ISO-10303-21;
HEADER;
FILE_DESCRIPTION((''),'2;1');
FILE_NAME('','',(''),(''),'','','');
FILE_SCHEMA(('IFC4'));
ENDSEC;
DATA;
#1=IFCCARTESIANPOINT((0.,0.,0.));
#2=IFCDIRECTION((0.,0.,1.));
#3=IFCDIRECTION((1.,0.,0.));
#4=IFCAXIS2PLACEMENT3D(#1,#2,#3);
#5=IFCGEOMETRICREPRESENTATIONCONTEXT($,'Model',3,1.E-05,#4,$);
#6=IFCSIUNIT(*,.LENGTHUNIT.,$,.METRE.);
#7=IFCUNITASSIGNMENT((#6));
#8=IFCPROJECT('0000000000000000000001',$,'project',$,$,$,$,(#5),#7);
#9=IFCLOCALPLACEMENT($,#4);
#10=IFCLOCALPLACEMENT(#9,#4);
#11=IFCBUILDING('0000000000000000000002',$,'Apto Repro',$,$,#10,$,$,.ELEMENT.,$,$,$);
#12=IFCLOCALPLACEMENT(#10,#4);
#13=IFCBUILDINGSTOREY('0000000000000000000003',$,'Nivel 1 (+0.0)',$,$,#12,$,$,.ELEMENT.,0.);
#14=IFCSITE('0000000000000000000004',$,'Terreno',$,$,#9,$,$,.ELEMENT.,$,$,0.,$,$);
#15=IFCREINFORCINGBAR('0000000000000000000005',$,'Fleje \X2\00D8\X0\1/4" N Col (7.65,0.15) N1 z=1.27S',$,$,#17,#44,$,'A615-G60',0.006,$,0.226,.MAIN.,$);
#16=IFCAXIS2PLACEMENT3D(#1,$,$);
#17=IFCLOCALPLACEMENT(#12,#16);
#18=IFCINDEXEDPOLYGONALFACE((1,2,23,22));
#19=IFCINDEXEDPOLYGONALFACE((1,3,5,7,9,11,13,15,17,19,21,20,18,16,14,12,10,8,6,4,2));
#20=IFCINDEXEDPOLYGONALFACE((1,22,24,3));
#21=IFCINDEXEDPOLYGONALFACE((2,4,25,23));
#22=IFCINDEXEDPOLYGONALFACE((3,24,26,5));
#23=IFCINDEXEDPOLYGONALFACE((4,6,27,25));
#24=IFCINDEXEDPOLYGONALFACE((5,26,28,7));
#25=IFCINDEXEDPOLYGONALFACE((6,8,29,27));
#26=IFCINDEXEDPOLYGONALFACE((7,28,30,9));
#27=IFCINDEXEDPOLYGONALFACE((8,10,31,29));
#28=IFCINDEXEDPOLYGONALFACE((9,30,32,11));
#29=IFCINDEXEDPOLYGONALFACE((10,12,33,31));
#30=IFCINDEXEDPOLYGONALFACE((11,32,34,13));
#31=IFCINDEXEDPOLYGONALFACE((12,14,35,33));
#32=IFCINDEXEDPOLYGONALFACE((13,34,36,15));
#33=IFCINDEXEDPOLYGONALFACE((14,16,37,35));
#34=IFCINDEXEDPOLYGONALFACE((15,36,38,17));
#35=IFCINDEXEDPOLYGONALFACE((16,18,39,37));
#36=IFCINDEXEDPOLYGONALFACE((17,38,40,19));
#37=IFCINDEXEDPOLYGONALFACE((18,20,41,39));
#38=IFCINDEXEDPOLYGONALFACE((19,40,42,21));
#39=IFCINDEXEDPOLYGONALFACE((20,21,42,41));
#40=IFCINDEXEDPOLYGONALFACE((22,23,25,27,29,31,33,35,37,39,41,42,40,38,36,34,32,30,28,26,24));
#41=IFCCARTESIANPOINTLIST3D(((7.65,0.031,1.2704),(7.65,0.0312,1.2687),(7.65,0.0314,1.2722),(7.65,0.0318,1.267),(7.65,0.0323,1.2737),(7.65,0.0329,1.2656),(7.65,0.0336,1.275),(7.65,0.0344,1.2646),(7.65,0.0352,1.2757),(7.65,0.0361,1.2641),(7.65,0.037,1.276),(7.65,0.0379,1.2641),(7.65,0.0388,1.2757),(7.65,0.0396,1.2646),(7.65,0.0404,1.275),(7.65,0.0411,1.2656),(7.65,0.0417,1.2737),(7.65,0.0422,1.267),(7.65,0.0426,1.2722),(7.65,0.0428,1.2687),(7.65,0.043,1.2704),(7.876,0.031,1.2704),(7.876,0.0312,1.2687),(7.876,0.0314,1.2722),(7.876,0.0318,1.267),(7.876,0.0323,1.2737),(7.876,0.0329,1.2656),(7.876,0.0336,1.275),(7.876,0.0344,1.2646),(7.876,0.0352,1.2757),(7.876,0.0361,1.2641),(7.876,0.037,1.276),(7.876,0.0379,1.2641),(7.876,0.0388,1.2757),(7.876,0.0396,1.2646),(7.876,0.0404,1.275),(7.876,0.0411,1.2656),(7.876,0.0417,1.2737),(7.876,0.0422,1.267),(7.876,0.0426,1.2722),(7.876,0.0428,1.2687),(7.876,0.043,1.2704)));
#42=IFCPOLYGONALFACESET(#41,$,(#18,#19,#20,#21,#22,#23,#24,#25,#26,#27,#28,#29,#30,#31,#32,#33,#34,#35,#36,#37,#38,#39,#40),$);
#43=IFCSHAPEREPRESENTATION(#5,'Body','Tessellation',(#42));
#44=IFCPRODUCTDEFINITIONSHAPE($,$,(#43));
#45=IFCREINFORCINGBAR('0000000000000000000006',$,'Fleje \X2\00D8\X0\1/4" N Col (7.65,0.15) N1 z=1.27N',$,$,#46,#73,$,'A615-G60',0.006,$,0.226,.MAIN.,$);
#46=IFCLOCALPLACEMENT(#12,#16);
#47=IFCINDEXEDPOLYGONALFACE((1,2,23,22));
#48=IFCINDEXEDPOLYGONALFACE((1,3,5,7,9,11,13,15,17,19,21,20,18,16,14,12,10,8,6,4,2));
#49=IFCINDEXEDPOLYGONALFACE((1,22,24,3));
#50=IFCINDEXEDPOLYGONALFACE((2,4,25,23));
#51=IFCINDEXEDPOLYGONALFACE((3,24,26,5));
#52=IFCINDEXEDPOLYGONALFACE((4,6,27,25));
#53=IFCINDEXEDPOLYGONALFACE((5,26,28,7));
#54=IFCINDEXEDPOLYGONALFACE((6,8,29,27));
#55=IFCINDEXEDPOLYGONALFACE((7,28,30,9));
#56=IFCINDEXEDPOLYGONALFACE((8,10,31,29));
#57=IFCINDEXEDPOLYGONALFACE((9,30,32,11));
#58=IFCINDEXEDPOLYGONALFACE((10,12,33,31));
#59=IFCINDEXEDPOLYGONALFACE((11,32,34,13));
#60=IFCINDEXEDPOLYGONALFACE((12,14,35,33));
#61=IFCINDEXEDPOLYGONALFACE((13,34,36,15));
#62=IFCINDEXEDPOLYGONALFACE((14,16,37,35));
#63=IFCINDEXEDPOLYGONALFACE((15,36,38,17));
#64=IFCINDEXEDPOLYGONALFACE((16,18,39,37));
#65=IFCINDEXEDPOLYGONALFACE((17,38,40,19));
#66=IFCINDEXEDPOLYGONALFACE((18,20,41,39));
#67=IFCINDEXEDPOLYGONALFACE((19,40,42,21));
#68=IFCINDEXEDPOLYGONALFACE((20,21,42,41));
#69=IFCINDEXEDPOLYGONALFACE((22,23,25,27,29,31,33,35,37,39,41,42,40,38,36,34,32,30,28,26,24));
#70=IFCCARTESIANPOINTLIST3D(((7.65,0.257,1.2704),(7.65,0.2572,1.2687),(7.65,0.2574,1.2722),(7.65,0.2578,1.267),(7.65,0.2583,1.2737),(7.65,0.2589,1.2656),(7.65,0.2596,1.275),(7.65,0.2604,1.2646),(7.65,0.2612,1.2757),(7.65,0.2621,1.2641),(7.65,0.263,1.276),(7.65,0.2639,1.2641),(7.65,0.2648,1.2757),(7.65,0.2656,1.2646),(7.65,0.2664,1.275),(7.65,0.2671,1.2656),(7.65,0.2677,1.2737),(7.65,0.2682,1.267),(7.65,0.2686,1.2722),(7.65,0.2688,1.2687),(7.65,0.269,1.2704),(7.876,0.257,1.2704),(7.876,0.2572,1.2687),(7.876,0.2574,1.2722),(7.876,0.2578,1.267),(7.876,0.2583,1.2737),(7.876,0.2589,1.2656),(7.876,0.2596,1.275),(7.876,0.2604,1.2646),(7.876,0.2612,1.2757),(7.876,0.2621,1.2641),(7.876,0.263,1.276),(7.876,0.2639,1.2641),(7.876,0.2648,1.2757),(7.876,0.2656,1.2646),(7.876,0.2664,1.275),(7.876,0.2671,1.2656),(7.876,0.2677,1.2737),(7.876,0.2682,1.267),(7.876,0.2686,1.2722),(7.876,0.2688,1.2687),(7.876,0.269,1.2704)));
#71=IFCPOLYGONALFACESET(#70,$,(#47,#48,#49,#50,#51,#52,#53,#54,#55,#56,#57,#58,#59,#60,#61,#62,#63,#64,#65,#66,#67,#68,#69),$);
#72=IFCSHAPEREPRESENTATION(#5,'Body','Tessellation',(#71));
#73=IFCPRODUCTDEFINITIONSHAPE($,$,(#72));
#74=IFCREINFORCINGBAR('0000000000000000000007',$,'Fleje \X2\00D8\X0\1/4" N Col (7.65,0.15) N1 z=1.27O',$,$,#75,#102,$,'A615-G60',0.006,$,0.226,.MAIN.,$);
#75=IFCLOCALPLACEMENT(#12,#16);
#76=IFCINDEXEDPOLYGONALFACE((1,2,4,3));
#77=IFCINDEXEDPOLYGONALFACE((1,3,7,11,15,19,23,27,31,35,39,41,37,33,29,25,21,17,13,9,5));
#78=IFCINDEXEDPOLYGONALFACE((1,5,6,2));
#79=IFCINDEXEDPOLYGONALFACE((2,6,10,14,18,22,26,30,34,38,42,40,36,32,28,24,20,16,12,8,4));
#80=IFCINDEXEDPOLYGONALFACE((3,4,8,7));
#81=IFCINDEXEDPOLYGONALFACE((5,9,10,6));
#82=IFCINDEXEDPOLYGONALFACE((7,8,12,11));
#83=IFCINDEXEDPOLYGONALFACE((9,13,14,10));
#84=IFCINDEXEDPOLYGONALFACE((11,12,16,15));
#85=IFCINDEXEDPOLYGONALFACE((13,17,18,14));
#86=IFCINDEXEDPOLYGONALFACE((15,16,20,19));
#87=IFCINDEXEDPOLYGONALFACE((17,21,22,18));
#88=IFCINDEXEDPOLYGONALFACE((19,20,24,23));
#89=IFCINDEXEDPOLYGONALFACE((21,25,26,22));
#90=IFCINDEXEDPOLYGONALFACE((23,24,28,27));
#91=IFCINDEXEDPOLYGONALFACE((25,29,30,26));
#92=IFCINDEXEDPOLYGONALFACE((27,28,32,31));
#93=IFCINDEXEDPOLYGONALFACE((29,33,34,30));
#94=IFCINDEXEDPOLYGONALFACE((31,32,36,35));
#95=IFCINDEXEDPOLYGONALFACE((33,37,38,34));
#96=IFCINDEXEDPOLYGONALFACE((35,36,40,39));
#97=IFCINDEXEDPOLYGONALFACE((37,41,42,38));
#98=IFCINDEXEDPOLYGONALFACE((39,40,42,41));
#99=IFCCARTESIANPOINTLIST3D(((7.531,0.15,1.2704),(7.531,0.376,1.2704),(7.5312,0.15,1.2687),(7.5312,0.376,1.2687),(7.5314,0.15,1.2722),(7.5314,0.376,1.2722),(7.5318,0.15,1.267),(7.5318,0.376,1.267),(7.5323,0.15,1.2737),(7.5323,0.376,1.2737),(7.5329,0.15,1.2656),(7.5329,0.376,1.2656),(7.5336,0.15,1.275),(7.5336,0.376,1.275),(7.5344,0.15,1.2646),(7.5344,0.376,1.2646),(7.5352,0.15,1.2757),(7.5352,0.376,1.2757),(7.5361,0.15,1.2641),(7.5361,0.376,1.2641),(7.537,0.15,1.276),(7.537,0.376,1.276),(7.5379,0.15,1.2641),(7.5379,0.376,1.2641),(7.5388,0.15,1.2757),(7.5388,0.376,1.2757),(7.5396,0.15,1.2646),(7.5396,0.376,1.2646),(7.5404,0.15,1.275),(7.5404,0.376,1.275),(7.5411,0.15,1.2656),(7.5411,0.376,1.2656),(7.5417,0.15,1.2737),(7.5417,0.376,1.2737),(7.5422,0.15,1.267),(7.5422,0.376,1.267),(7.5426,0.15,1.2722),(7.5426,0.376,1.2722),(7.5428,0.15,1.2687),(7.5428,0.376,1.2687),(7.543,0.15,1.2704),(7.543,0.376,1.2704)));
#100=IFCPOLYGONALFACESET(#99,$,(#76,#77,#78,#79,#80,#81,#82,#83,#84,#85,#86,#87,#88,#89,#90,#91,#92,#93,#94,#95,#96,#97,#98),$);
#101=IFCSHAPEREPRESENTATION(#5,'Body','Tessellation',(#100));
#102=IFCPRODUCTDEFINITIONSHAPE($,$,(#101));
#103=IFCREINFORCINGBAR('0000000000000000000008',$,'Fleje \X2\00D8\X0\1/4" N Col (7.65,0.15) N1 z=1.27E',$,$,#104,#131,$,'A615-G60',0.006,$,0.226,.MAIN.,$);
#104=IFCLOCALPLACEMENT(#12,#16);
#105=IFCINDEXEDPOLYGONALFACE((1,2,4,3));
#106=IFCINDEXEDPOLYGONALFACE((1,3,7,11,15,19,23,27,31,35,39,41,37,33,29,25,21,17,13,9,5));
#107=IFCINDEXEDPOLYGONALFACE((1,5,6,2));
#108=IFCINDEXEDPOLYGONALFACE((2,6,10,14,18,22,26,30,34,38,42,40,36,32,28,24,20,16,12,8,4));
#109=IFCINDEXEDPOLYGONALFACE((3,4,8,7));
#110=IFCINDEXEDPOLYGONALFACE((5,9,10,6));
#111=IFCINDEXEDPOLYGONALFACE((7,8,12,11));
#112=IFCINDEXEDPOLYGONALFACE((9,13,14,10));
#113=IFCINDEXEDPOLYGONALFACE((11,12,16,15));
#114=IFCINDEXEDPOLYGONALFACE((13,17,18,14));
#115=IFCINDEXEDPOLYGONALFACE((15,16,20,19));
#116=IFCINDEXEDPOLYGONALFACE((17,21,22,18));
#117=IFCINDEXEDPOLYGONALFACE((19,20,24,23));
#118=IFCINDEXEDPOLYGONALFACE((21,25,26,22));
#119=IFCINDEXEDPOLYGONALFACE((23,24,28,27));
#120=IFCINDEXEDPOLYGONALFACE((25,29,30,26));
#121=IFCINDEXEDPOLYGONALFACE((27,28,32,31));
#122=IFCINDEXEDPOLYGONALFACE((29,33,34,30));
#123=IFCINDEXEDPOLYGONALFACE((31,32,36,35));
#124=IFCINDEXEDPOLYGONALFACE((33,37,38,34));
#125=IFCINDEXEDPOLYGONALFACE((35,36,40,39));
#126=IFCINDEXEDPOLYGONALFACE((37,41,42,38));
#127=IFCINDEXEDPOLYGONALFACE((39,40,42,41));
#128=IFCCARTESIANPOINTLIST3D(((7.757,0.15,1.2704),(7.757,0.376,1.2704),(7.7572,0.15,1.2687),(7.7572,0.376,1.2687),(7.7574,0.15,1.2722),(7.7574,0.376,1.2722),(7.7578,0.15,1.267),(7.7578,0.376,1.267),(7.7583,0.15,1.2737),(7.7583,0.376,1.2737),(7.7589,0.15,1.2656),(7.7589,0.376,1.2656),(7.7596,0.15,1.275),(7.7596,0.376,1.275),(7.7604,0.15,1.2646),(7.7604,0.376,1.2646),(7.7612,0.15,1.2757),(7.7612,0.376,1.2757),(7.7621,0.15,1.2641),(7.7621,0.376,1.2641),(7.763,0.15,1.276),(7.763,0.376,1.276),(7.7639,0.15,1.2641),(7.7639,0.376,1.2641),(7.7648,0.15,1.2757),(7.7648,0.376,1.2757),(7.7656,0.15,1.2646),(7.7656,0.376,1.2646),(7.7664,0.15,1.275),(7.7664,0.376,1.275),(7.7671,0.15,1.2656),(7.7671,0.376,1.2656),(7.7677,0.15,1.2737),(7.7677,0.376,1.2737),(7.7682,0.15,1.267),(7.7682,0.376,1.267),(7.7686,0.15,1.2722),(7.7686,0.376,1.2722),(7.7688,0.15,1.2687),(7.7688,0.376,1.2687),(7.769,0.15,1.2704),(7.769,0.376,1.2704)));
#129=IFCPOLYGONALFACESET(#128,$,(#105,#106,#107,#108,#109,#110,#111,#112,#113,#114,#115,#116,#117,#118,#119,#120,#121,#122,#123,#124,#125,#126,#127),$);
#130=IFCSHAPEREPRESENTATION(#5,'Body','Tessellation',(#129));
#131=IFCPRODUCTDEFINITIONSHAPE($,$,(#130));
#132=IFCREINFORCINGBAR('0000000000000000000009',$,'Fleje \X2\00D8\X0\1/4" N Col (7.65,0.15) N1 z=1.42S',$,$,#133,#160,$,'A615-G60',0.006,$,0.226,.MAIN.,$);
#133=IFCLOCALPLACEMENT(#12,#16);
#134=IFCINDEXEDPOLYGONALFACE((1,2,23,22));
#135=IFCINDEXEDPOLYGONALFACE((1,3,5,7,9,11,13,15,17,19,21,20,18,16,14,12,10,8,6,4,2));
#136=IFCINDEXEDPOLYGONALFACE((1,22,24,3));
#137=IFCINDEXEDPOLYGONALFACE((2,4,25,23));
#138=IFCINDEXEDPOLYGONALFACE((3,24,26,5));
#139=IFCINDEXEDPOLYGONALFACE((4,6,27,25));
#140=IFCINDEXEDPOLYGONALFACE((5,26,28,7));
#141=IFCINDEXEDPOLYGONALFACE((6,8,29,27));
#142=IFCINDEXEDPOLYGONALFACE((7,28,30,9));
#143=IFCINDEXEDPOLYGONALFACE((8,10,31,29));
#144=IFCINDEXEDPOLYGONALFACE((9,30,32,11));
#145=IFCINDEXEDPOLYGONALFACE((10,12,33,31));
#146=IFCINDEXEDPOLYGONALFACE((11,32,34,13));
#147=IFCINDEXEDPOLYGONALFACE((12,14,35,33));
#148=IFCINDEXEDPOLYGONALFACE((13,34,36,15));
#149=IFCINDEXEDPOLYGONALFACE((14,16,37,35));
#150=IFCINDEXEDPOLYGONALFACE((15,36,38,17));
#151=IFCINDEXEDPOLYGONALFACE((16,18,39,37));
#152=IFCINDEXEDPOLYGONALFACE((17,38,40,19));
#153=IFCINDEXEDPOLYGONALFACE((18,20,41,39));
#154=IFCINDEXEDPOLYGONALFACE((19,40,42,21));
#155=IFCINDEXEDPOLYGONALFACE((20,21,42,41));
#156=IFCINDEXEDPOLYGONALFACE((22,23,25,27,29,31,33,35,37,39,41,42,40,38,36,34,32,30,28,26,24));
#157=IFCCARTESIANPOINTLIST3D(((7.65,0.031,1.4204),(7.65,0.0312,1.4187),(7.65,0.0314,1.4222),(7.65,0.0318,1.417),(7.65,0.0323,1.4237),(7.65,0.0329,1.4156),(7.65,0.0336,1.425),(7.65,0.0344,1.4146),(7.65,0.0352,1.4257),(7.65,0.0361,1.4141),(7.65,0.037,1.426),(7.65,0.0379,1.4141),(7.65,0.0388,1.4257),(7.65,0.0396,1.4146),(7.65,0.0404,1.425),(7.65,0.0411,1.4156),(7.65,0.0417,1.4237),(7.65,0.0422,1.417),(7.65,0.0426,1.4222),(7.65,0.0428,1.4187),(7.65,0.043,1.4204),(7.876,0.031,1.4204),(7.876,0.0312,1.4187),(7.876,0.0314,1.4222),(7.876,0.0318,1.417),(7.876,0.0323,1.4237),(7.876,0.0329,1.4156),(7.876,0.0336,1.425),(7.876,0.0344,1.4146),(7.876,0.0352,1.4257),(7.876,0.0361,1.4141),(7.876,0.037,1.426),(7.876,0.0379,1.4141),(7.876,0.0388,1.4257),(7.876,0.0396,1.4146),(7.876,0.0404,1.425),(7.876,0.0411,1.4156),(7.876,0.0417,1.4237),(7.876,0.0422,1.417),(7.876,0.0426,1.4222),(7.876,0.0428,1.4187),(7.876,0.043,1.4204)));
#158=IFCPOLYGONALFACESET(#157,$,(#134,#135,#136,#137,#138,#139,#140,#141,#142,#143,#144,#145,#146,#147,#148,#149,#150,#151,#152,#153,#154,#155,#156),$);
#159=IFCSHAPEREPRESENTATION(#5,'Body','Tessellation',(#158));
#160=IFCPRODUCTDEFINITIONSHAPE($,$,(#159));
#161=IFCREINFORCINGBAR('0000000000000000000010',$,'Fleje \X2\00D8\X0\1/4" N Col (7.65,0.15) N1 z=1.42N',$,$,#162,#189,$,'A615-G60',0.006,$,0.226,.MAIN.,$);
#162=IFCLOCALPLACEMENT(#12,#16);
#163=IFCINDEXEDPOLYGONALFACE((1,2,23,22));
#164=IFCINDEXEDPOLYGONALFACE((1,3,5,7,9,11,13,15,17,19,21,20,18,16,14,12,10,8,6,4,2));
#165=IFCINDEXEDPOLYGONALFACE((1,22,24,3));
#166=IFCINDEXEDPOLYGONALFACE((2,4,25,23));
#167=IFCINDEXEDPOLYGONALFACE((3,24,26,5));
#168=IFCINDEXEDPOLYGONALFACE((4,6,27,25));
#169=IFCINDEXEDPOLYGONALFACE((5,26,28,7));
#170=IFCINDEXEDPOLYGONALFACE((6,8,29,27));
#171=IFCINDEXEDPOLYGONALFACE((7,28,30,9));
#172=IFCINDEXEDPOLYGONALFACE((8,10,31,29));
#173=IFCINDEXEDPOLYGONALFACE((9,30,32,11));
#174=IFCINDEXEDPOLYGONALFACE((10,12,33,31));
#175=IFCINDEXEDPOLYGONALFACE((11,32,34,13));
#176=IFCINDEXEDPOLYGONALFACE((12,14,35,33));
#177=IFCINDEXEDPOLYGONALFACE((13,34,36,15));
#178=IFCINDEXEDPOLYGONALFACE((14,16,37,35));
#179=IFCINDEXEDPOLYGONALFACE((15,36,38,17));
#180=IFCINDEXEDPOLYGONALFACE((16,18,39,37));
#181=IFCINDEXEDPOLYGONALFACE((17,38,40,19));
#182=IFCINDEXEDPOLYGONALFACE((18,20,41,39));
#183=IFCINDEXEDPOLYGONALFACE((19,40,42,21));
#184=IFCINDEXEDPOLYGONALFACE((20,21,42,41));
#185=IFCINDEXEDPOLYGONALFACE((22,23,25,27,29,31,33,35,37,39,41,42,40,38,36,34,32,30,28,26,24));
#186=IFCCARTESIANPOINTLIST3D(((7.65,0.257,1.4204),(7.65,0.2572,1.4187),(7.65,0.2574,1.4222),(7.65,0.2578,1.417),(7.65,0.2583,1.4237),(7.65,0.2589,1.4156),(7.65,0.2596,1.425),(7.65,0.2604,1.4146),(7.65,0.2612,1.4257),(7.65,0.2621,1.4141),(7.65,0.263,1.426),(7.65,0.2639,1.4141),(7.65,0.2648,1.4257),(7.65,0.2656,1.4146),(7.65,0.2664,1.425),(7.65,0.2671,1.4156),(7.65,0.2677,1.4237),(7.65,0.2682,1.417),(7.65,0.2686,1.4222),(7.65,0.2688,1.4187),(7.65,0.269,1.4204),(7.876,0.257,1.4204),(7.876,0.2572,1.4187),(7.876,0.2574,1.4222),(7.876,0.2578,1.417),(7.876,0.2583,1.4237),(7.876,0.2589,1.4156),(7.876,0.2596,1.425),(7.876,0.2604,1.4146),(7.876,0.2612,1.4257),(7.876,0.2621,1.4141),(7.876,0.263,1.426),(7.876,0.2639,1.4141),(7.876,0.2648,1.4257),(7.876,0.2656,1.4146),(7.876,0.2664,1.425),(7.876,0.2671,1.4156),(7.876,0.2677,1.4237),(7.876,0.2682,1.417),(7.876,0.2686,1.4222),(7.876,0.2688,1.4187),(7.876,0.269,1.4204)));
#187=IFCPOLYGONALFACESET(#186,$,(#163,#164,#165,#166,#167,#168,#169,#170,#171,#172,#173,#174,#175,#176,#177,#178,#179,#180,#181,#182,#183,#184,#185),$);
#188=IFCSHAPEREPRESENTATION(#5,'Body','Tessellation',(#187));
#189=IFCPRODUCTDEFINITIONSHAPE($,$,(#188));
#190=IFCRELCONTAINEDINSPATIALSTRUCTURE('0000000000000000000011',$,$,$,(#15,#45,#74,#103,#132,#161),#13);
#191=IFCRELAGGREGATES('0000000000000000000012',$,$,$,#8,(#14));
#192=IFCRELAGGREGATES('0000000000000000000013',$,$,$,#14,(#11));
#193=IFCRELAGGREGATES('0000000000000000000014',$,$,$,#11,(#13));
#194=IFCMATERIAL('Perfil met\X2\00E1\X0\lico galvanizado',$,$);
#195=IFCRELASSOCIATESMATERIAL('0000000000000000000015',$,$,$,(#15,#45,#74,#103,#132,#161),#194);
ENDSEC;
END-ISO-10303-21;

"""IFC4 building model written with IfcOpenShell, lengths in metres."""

from ifc_helpers import new_model, si_unit, frame, origin_with_axes, origin_2d_with_axis, place, context, project, spatial, circle, extrude, material, element, save


model = new_model("IFC4")

# Units and contexts
model_context = context("Model", 3, precision=1e-05, world=origin_with_axes())
ifc_project = project(units=[si_unit("LENGTHUNIT", "METRE")], contexts=[model_context])

# Site, building, storey
site_placement = place(None, origin_with_axes())
site = spatial("IfcSite", under=ifc_project, at=site_placement, Name="Terreno", CompositionType="ELEMENT", RefElevation=0.0)
building_placement = place(site_placement, origin_with_axes())
building = spatial("IfcBuilding", under=site, at=building_placement, Name="Apto Repro", CompositionType="ELEMENT")
storey_placement = place(building_placement, origin_with_axes())
storey = spatial("IfcBuildingStorey", under=building, at=storey_placement, Name="Nivel 1 (+0.0)", CompositionType="ELEMENT", Elevation=0.0)

# Reinforcing bars
ifc_material = material(Name="Perfil metálico galvanizado")
reinforcing_bar_1_placement = place(storey_placement, origin_with_axes())
element("IfcReinforcingBar", 1, at=reinforcing_bar_1_placement, inside=storey, material=ifc_material, Name="Fleje Ø1/4\" N Col (7.65,0.15) N1 z=1.27S", SteelGrade="A615-G60", BarLength=0.226, NominalDiameter=0.006, PredefinedType="MAIN", context=model_context, shape_type="SweptSolid", body=[
    extrude(circle(Radius=0.006, at=origin_2d_with_axis()), frame((7.65, 0.037, 1.27), z_axis=(1.0, 0.0, 0.0), x_axis=(0.0, 0.0, 1.0)), (0.0, 0.0, 1.0), 0.226),
])
reinforcing_bar_2_placement = place(storey_placement, origin_with_axes())
element("IfcReinforcingBar", 2, at=reinforcing_bar_2_placement, inside=storey, material=ifc_material, Name="Fleje Ø1/4\" N Col (7.65,0.15) N1 z=1.27N", SteelGrade="A615-G60", BarLength=0.226, NominalDiameter=0.006, PredefinedType="MAIN", context=model_context, shape_type="SweptSolid", body=[
    extrude(circle(Radius=0.006, at=origin_2d_with_axis()), frame((7.65, 0.263, 1.27), z_axis=(1.0, 0.0, 0.0), x_axis=(0.0, 0.0, 1.0)), (0.0, 0.0, 1.0), 0.226),
])
reinforcing_bar_3_placement = place(storey_placement, origin_with_axes())
element("IfcReinforcingBar", 3, at=reinforcing_bar_3_placement, inside=storey, material=ifc_material, Name="Fleje Ø1/4\" N Col (7.65,0.15) N1 z=1.27O", SteelGrade="A615-G60", BarLength=0.226, NominalDiameter=0.006, PredefinedType="MAIN", context=model_context, shape_type="SweptSolid", body=[
    extrude(circle(Radius=0.006, at=origin_2d_with_axis()), frame((7.537, 0.15, 1.27), z_axis=(0.0, 1.0, 0.0), x_axis=(0.0, 0.0, 1.0)), (0.0, 0.0, 1.0), 0.226),
])
reinforcing_bar_4_placement = place(storey_placement, origin_with_axes())
element("IfcReinforcingBar", 4, at=reinforcing_bar_4_placement, inside=storey, material=ifc_material, Name="Fleje Ø1/4\" N Col (7.65,0.15) N1 z=1.27E", SteelGrade="A615-G60", BarLength=0.226, NominalDiameter=0.006, PredefinedType="MAIN", context=model_context, shape_type="SweptSolid", body=[
    extrude(circle(Radius=0.006, at=origin_2d_with_axis()), frame((7.763, 0.15, 1.27), z_axis=(0.0, 1.0, 0.0), x_axis=(0.0, 0.0, 1.0)), (0.0, 0.0, 1.0), 0.226),
])
reinforcing_bar_5_placement = place(storey_placement, origin_with_axes())
element("IfcReinforcingBar", 5, at=reinforcing_bar_5_placement, inside=storey, material=ifc_material, Name="Fleje Ø1/4\" N Col (7.65,0.15) N1 z=1.42S", SteelGrade="A615-G60", BarLength=0.226, NominalDiameter=0.006, PredefinedType="MAIN", context=model_context, shape_type="SweptSolid", body=[
    extrude(circle(Radius=0.006, at=origin_2d_with_axis()), frame((7.65, 0.037, 1.42), z_axis=(1.0, 0.0, 0.0), x_axis=(0.0, 0.0, 1.0)), (0.0, 0.0, 1.0), 0.226),
])
reinforcing_bar_6_placement = place(storey_placement, origin_with_axes())
element("IfcReinforcingBar", 6, at=reinforcing_bar_6_placement, inside=storey, material=ifc_material, Name="Fleje Ø1/4\" N Col (7.65,0.15) N1 z=1.42N", SteelGrade="A615-G60", BarLength=0.226, NominalDiameter=0.006, PredefinedType="MAIN", context=model_context, shape_type="SweptSolid", body=[
    extrude(circle(Radius=0.006, at=origin_2d_with_axis()), frame((7.65, 0.263, 1.42), z_axis=(1.0, 0.0, 0.0), x_axis=(0.0, 0.0, 1.0)), (0.0, 0.0, 1.0), 0.226),
])

save(model, "model.ifc")
